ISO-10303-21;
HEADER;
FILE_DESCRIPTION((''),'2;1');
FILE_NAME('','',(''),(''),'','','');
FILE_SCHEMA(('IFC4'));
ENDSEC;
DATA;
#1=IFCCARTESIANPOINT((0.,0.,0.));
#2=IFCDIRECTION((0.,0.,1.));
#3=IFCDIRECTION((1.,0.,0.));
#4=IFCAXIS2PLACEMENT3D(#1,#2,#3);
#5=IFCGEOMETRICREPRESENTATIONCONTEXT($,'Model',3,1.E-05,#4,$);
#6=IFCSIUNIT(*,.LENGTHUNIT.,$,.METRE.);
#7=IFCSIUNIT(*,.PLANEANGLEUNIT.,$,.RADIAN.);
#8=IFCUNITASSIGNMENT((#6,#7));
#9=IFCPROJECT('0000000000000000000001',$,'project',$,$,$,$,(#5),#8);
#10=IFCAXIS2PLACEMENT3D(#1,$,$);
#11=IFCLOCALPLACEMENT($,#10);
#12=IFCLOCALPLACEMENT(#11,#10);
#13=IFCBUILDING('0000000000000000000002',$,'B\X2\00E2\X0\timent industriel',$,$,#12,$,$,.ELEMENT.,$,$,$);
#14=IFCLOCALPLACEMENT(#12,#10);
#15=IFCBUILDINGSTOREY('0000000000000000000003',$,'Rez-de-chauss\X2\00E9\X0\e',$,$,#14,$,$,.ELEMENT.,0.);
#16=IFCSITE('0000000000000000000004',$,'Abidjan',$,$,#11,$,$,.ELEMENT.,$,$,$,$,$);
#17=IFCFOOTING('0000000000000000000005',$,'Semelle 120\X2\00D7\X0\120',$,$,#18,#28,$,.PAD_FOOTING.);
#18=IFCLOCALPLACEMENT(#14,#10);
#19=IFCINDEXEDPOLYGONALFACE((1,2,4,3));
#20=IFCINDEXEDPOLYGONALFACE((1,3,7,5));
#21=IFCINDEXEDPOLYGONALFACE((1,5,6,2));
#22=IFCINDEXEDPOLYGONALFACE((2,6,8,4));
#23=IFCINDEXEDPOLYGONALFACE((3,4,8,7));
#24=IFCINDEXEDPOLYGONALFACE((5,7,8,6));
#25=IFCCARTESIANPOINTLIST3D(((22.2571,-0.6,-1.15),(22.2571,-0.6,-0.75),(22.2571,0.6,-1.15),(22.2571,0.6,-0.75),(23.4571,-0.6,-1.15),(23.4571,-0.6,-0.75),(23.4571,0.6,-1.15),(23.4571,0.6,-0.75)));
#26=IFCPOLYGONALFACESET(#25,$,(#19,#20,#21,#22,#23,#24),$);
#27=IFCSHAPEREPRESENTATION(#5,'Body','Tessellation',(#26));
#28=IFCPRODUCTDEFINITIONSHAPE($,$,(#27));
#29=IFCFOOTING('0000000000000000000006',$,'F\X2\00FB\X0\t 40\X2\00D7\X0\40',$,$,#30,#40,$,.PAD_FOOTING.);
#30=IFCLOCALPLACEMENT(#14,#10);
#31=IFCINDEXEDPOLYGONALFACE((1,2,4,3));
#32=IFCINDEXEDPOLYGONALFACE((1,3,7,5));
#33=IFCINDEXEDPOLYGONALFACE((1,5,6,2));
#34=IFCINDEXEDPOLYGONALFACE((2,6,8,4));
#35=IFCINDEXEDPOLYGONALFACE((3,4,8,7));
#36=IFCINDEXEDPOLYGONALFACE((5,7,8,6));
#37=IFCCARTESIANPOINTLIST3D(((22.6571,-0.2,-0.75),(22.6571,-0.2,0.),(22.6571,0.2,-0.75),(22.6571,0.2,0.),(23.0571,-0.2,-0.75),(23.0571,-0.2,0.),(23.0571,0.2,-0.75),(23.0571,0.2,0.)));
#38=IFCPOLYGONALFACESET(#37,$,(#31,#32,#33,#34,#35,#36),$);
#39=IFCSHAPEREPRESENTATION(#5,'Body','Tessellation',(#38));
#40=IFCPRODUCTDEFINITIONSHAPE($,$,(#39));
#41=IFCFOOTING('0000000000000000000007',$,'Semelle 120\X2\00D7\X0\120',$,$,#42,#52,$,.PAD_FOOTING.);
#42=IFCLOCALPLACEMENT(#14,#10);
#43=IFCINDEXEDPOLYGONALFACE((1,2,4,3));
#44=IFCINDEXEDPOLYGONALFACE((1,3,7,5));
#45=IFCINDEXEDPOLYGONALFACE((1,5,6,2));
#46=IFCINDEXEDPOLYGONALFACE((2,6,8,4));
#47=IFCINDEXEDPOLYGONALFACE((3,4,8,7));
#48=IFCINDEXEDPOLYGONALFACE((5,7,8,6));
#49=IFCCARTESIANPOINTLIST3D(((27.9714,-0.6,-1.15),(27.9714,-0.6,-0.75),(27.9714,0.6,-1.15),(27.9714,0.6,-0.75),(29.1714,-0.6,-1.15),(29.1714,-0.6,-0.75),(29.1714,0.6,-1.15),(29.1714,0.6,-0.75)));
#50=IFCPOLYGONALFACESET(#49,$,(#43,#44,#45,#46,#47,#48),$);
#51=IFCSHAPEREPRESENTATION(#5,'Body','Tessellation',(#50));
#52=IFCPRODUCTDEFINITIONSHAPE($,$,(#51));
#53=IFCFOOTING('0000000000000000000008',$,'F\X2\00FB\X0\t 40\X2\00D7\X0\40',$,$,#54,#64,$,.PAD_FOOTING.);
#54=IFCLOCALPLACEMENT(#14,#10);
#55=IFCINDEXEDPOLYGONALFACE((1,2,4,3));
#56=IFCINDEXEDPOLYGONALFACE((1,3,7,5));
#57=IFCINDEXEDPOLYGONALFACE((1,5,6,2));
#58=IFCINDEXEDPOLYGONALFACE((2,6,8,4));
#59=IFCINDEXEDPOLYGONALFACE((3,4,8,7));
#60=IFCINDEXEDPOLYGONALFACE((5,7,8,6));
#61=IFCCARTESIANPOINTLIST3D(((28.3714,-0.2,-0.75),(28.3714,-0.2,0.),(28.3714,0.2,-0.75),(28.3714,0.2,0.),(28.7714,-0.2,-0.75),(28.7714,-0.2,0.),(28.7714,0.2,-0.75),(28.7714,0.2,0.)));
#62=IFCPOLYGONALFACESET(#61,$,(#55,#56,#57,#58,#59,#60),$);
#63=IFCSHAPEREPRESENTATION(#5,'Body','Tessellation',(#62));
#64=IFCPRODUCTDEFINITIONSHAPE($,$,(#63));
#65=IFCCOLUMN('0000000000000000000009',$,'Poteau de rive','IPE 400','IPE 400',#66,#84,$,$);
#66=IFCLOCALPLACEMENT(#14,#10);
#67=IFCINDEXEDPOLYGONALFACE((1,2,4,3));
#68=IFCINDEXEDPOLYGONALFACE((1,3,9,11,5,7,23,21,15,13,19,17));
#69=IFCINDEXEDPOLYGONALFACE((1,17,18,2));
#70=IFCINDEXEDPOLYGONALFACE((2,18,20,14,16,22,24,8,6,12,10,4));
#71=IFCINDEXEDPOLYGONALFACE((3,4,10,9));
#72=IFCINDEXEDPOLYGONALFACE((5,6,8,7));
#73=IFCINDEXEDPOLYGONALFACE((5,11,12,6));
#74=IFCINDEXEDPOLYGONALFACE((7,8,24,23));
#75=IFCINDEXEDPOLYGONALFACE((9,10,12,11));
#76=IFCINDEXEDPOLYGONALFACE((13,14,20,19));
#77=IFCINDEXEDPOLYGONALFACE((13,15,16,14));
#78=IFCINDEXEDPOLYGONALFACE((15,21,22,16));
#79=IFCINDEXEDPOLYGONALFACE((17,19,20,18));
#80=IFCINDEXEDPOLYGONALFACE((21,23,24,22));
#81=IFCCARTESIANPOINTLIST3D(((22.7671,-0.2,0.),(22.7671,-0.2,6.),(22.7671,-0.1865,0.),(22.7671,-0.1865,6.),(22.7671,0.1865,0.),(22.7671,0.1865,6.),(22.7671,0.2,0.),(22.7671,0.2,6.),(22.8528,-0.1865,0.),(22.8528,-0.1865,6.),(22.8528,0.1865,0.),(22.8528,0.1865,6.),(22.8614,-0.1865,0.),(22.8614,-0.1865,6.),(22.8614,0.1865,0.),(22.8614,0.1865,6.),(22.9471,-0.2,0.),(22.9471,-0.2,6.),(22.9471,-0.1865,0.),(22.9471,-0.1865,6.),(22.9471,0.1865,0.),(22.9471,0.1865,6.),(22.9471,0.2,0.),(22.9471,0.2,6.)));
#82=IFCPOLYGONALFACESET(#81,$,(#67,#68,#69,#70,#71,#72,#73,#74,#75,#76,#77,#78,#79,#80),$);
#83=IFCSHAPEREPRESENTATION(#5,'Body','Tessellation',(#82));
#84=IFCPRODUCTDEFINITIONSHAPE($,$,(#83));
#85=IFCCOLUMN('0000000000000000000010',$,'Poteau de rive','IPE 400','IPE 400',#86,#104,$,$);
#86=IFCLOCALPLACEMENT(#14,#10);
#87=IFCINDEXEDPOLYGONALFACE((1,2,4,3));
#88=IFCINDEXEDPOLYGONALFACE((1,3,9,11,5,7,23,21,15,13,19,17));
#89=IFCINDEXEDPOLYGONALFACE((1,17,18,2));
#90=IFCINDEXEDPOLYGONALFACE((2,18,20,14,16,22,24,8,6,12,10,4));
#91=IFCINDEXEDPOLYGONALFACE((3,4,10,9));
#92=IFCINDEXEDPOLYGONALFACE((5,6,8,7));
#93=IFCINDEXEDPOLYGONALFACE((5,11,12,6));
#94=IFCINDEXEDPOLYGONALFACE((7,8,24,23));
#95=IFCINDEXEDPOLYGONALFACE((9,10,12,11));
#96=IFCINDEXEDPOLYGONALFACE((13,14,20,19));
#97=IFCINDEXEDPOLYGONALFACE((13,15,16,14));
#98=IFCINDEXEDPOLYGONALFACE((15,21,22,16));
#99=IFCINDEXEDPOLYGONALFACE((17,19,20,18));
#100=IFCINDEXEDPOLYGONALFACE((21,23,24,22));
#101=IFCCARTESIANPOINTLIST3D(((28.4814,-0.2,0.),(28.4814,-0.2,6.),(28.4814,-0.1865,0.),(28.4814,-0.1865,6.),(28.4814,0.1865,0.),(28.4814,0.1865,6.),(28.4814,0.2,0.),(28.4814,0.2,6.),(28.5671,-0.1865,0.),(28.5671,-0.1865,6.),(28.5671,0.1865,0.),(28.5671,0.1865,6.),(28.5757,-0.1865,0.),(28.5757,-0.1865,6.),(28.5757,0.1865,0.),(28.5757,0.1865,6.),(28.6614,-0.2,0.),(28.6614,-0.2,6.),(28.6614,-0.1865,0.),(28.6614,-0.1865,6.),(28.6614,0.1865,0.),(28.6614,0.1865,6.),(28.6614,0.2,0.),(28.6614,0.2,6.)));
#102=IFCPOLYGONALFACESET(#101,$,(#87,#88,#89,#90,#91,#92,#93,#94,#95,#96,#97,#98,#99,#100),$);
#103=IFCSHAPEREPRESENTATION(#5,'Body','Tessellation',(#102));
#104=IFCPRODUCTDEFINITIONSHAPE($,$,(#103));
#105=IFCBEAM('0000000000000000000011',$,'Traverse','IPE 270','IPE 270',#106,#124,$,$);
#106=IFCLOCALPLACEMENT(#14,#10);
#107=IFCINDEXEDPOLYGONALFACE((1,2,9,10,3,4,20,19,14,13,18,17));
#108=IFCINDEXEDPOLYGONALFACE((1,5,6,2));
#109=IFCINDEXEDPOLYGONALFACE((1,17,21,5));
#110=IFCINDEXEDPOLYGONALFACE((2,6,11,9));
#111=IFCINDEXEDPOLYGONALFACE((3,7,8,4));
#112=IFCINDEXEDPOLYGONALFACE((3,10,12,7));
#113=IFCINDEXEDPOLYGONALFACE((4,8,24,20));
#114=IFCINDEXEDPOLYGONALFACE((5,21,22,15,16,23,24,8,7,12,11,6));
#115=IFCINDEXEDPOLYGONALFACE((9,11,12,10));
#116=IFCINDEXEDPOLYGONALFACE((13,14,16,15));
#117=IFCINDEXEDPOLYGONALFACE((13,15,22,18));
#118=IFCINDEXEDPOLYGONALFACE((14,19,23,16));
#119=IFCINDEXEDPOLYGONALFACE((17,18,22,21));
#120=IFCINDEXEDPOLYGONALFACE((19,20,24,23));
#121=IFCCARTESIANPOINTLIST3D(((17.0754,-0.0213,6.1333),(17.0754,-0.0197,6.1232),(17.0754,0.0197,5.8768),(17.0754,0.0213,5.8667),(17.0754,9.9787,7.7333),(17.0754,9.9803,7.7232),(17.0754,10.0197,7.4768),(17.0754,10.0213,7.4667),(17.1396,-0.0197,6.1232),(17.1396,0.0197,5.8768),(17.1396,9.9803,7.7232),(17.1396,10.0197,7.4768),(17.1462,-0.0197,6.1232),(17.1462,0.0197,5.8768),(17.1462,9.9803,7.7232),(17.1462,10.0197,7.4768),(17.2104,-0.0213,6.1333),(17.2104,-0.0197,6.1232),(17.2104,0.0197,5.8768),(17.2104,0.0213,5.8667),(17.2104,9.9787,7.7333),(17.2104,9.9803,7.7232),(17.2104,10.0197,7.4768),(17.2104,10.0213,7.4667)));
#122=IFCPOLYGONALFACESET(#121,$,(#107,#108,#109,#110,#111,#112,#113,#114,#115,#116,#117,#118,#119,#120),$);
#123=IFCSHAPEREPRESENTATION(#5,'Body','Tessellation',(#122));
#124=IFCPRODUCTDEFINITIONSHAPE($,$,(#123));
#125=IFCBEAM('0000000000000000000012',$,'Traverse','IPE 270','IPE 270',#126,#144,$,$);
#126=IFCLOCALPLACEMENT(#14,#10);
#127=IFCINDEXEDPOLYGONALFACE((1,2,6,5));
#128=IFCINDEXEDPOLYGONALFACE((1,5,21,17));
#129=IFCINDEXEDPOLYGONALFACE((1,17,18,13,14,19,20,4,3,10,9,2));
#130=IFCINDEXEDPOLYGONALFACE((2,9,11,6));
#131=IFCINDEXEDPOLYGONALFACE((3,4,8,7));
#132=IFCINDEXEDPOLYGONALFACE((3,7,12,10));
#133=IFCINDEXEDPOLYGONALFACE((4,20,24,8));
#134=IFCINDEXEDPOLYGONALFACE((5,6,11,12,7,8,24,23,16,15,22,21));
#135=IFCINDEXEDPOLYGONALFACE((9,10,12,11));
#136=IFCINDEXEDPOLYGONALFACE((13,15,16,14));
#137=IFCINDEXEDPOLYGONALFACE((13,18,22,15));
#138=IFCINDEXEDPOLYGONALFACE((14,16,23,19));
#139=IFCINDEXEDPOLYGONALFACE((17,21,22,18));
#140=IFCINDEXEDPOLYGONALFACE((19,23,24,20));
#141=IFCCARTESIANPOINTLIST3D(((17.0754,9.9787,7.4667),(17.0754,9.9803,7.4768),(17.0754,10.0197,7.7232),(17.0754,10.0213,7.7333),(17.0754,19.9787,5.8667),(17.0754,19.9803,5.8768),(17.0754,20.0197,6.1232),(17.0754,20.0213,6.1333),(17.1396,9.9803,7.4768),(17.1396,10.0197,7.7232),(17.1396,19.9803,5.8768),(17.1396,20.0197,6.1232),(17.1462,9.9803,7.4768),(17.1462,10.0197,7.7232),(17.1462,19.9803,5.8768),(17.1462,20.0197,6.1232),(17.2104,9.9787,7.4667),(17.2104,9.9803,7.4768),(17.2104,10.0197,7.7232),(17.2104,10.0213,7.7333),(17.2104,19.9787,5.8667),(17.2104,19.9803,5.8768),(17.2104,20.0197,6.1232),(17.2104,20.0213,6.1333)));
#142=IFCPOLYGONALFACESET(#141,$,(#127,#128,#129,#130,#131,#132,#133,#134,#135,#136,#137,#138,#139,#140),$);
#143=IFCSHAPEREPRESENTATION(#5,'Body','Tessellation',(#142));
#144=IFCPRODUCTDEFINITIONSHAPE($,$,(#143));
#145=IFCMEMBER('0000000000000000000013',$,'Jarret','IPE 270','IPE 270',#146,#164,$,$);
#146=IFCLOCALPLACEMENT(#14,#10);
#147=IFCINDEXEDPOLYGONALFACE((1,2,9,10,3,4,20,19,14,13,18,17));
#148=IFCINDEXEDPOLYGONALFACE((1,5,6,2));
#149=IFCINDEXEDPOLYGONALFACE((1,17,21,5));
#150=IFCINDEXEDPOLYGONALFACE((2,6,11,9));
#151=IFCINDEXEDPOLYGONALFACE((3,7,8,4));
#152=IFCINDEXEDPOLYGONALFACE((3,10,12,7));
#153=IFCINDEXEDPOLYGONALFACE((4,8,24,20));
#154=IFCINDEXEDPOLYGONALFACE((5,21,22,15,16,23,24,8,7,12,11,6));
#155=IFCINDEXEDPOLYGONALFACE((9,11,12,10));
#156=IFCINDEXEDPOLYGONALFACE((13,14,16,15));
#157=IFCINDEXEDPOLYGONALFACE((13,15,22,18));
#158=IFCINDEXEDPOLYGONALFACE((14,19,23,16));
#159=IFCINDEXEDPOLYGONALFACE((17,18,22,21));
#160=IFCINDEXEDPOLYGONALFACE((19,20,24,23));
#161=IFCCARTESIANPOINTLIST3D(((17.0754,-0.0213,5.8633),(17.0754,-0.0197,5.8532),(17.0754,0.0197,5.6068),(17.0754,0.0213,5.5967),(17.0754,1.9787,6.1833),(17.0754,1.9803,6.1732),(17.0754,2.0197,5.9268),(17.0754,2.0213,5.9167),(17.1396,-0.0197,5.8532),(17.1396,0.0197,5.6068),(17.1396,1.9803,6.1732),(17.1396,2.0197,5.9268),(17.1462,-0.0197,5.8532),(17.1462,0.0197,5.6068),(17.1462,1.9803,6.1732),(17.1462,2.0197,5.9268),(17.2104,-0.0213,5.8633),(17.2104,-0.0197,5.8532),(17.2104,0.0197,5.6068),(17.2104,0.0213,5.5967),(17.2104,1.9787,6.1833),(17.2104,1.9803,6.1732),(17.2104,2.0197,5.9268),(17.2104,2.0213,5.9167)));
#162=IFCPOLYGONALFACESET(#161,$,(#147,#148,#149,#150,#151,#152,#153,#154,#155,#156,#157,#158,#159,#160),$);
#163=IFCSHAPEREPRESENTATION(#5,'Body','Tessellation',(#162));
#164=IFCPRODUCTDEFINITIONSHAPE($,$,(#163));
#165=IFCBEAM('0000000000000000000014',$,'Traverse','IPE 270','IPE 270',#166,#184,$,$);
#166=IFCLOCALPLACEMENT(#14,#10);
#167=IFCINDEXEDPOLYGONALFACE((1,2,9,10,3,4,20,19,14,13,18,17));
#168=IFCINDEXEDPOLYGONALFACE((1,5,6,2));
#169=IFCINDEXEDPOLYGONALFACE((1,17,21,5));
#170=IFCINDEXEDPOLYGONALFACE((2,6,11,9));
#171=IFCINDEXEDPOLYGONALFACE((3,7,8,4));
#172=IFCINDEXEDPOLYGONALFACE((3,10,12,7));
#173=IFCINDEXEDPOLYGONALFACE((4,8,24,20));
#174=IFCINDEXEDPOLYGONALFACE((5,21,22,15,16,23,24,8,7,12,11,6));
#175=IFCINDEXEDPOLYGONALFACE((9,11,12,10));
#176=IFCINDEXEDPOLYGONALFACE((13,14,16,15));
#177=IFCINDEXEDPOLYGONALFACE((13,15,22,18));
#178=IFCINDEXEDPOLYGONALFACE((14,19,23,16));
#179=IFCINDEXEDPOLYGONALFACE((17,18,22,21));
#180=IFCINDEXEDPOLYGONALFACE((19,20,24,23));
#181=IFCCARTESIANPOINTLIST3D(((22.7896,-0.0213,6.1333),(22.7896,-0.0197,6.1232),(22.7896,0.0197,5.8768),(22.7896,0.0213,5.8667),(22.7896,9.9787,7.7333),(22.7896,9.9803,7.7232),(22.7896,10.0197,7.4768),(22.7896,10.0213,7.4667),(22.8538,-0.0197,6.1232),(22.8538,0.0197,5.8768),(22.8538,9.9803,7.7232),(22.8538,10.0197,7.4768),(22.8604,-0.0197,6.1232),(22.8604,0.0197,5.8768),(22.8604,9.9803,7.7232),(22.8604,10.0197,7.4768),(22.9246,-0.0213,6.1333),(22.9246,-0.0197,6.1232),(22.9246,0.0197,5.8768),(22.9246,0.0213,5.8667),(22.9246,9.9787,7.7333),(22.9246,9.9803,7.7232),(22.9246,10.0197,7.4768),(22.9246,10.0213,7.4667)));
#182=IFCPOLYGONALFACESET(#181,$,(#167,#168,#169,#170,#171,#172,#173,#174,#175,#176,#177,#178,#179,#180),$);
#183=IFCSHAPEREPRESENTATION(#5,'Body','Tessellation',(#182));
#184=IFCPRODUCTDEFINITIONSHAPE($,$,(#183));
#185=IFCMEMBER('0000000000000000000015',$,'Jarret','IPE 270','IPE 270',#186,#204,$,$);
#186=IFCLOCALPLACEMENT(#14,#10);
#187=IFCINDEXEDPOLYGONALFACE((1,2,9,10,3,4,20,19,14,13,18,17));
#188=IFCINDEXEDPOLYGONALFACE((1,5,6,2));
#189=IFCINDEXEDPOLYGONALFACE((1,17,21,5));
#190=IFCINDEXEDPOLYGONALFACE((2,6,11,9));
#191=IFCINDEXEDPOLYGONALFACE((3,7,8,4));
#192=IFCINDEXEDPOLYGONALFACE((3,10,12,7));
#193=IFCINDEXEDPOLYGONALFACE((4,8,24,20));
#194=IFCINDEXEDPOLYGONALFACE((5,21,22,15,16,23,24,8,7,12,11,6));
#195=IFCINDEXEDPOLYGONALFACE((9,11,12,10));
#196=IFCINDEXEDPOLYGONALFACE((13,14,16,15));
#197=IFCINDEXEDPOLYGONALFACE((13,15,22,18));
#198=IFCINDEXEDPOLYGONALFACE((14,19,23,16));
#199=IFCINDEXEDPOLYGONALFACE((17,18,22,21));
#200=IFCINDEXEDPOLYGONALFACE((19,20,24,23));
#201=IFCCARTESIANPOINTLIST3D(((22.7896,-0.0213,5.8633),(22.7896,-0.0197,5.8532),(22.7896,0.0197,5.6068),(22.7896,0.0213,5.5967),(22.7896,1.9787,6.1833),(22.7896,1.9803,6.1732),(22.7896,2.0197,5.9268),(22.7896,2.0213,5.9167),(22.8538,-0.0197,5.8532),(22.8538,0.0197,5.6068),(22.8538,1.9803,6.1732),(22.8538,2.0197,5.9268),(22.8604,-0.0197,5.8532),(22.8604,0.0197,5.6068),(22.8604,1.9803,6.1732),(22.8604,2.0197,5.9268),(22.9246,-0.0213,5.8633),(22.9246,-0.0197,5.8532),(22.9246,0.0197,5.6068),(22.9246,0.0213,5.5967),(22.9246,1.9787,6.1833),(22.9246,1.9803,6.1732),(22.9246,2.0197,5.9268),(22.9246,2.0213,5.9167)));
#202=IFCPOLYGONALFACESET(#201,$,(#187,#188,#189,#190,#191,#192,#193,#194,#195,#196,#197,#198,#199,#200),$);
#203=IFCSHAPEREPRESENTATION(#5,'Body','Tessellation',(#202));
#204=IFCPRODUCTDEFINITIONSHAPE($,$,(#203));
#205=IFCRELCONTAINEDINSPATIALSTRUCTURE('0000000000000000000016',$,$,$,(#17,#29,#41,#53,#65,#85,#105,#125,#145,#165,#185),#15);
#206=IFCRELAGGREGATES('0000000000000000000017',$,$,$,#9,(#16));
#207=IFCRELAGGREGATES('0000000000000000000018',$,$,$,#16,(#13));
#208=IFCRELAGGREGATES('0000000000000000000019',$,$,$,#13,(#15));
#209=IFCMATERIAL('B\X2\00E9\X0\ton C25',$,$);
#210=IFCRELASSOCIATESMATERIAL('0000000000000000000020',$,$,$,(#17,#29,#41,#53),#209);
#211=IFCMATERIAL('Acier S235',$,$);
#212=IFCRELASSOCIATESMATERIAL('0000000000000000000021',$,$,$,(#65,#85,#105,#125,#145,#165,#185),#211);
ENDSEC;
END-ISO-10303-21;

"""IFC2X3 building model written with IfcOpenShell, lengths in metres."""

from ifc_helpers import new_model, si_unit, frame, origin, origin_with_axes, origin_2d, place, context, project, spatial, rectangle, i_section, extrude, material, element, save


model = new_model("IFC2X3")

# Units and contexts
model_context = context("Model", 3, precision=1e-05, world=origin_with_axes())
ifc_project = project(units=[si_unit("LENGTHUNIT", "METRE"), si_unit("PLANEANGLEUNIT", "RADIAN")], contexts=[model_context])

# Site, building, storey
site_placement = place(None, origin())
site = spatial("IfcSite", under=ifc_project, at=site_placement, Name="Abidjan", CompositionType="ELEMENT")
building_placement = place(site_placement, origin())
building = spatial("IfcBuilding", under=site, at=building_placement, Name="Bâtiment industriel", CompositionType="ELEMENT")
storey_placement = place(building_placement, origin())
storey = spatial("IfcBuildingStorey", under=building, at=storey_placement, Name="Rez-de-chaussée", CompositionType="ELEMENT", Elevation=0.0)

# Footings
ifc_material_1 = material(Name="Béton C25")
footing_1_placement = place(storey_placement, frame((22.8571, 0.0, -1.15), z_axis=(0.0, 0.0, 1.0), x_axis=(1.0, 0.0, 0.0)))
element("IfcFooting", 1, at=footing_1_placement, inside=storey, material=ifc_material_1, Name="Semelle 120×120", PredefinedType="PAD_FOOTING", context=model_context, shape_type="SweptSolid", body=[
    extrude(rectangle(XDim=1.2, YDim=1.2, at=origin_2d()), origin(), (0.0, 0.0, 1.0), 0.4),
])
footing_2_placement = place(storey_placement, frame((22.8571, 0.0, -0.75), z_axis=(0.0, 0.0, 1.0), x_axis=(1.0, 0.0, 0.0)))
element("IfcFooting", 2, at=footing_2_placement, inside=storey, material=ifc_material_1, Name="Fût 40×40", PredefinedType="PAD_FOOTING", context=model_context, shape_type="SweptSolid", body=[
    extrude(rectangle(XDim=0.4, YDim=0.4, at=origin_2d()), origin(), (0.0, 0.0, 1.0), 0.75),
])
footing_3_placement = place(storey_placement, frame((28.5714, 0.0, -1.15), z_axis=(0.0, 0.0, 1.0), x_axis=(1.0, 0.0, 0.0)))
element("IfcFooting", 3, at=footing_3_placement, inside=storey, material=ifc_material_1, Name="Semelle 120×120", PredefinedType="PAD_FOOTING", context=model_context, shape_type="SweptSolid", body=[
    extrude(rectangle(XDim=1.2, YDim=1.2, at=origin_2d()), origin(), (0.0, 0.0, 1.0), 0.4),
])
footing_4_placement = place(storey_placement, frame((28.5714, 0.0, -0.75), z_axis=(0.0, 0.0, 1.0), x_axis=(1.0, 0.0, 0.0)))
element("IfcFooting", 4, at=footing_4_placement, inside=storey, material=ifc_material_1, Name="Fût 40×40", PredefinedType="PAD_FOOTING", context=model_context, shape_type="SweptSolid", body=[
    extrude(rectangle(XDim=0.4, YDim=0.4, at=origin_2d()), origin(), (0.0, 0.0, 1.0), 0.75),
])

# Columns
ifc_material_2 = material(Name="Acier S235")
for number, where, z_axis, x_axis, name in (
    (5, (22.8571, 0.0, 0.0), (0.0, 0.0, 1.0), (1.0, 0.0, 0.0), "Poteau de rive"),
    (6, (28.5714, 0.0, 0.0), (0.0, 0.0, 1.0), (1.0, 0.0, 0.0), "Poteau de rive"),
):
    element("IfcColumn", number, at=place(storey_placement, frame(where, z_axis=z_axis, x_axis=x_axis)), inside=storey, material=ifc_material_2, Name=name, Description="IPE 400", ObjectType="IPE 400", context=model_context, shape_type="SweptSolid", body=[
        extrude(i_section(OverallWidth=0.18, OverallDepth=0.4, WebThickness=0.0086, FlangeThickness=0.0135, at=origin_2d()), origin(), (0.0, 0.0, 1.0), 6.0),
    ])

# Beams
for number, where, z_axis, x_axis, name in (
    (7, (17.1429, 0.0, 6.0), (0.0, 0.98744, 0.15799), (1.0, 0.0, 0.0), "Traverse"),
    (8, (17.1429, 10.0, 7.6), (0.0, 0.98744, -0.15799), (1.0, 0.0, 0.0), "Traverse"),
):
    element("IfcBeam", number, at=place(storey_placement, frame(where, z_axis=z_axis, x_axis=x_axis)), inside=storey, material=ifc_material_2, Name=name, Description="IPE 270", ObjectType="IPE 270", context=model_context, shape_type="SweptSolid", body=[
        extrude(i_section(OverallWidth=0.135, OverallDepth=0.27, WebThickness=0.0066, FlangeThickness=0.0102, at=origin_2d()), origin(), (0.0, 0.0, 1.0), 10.1272),
    ])

# Member
member_1_placement = place(storey_placement, frame((17.1429, 0.0, 5.73), z_axis=(0.0, 0.98744, 0.15799), x_axis=(1.0, 0.0, 0.0)))
element("IfcMember", 9, at=member_1_placement, inside=storey, material=ifc_material_2, Name="Jarret", Description="IPE 270", ObjectType="IPE 270", context=model_context, shape_type="SweptSolid", body=[
    extrude(i_section(OverallWidth=0.135, OverallDepth=0.27, WebThickness=0.0066, FlangeThickness=0.0102, at=origin_2d()), origin(), (0.0, 0.0, 1.0), 2.0254),
])

# Beam
beam_1_placement = place(storey_placement, frame((22.8571, 0.0, 6.0), z_axis=(0.0, 0.98744, 0.15799), x_axis=(1.0, 0.0, 0.0)))
element("IfcBeam", 10, at=beam_1_placement, inside=storey, material=ifc_material_2, Name="Traverse", Description="IPE 270", ObjectType="IPE 270", context=model_context, shape_type="SweptSolid", body=[
    extrude(i_section(OverallWidth=0.135, OverallDepth=0.27, WebThickness=0.0066, FlangeThickness=0.0102, at=origin_2d()), origin(), (0.0, 0.0, 1.0), 10.1272),
])

# Member
member_2_placement = place(storey_placement, frame((22.8571, 0.0, 5.73), z_axis=(0.0, 0.98744, 0.15799), x_axis=(1.0, 0.0, 0.0)))
element("IfcMember", 11, at=member_2_placement, inside=storey, material=ifc_material_2, Name="Jarret", Description="IPE 270", ObjectType="IPE 270", context=model_context, shape_type="SweptSolid", body=[
    extrude(i_section(OverallWidth=0.135, OverallDepth=0.27, WebThickness=0.0066, FlangeThickness=0.0102, at=origin_2d()), origin(), (0.0, 0.0, 1.0), 2.0254),
])

save(model, "model.ifc")
